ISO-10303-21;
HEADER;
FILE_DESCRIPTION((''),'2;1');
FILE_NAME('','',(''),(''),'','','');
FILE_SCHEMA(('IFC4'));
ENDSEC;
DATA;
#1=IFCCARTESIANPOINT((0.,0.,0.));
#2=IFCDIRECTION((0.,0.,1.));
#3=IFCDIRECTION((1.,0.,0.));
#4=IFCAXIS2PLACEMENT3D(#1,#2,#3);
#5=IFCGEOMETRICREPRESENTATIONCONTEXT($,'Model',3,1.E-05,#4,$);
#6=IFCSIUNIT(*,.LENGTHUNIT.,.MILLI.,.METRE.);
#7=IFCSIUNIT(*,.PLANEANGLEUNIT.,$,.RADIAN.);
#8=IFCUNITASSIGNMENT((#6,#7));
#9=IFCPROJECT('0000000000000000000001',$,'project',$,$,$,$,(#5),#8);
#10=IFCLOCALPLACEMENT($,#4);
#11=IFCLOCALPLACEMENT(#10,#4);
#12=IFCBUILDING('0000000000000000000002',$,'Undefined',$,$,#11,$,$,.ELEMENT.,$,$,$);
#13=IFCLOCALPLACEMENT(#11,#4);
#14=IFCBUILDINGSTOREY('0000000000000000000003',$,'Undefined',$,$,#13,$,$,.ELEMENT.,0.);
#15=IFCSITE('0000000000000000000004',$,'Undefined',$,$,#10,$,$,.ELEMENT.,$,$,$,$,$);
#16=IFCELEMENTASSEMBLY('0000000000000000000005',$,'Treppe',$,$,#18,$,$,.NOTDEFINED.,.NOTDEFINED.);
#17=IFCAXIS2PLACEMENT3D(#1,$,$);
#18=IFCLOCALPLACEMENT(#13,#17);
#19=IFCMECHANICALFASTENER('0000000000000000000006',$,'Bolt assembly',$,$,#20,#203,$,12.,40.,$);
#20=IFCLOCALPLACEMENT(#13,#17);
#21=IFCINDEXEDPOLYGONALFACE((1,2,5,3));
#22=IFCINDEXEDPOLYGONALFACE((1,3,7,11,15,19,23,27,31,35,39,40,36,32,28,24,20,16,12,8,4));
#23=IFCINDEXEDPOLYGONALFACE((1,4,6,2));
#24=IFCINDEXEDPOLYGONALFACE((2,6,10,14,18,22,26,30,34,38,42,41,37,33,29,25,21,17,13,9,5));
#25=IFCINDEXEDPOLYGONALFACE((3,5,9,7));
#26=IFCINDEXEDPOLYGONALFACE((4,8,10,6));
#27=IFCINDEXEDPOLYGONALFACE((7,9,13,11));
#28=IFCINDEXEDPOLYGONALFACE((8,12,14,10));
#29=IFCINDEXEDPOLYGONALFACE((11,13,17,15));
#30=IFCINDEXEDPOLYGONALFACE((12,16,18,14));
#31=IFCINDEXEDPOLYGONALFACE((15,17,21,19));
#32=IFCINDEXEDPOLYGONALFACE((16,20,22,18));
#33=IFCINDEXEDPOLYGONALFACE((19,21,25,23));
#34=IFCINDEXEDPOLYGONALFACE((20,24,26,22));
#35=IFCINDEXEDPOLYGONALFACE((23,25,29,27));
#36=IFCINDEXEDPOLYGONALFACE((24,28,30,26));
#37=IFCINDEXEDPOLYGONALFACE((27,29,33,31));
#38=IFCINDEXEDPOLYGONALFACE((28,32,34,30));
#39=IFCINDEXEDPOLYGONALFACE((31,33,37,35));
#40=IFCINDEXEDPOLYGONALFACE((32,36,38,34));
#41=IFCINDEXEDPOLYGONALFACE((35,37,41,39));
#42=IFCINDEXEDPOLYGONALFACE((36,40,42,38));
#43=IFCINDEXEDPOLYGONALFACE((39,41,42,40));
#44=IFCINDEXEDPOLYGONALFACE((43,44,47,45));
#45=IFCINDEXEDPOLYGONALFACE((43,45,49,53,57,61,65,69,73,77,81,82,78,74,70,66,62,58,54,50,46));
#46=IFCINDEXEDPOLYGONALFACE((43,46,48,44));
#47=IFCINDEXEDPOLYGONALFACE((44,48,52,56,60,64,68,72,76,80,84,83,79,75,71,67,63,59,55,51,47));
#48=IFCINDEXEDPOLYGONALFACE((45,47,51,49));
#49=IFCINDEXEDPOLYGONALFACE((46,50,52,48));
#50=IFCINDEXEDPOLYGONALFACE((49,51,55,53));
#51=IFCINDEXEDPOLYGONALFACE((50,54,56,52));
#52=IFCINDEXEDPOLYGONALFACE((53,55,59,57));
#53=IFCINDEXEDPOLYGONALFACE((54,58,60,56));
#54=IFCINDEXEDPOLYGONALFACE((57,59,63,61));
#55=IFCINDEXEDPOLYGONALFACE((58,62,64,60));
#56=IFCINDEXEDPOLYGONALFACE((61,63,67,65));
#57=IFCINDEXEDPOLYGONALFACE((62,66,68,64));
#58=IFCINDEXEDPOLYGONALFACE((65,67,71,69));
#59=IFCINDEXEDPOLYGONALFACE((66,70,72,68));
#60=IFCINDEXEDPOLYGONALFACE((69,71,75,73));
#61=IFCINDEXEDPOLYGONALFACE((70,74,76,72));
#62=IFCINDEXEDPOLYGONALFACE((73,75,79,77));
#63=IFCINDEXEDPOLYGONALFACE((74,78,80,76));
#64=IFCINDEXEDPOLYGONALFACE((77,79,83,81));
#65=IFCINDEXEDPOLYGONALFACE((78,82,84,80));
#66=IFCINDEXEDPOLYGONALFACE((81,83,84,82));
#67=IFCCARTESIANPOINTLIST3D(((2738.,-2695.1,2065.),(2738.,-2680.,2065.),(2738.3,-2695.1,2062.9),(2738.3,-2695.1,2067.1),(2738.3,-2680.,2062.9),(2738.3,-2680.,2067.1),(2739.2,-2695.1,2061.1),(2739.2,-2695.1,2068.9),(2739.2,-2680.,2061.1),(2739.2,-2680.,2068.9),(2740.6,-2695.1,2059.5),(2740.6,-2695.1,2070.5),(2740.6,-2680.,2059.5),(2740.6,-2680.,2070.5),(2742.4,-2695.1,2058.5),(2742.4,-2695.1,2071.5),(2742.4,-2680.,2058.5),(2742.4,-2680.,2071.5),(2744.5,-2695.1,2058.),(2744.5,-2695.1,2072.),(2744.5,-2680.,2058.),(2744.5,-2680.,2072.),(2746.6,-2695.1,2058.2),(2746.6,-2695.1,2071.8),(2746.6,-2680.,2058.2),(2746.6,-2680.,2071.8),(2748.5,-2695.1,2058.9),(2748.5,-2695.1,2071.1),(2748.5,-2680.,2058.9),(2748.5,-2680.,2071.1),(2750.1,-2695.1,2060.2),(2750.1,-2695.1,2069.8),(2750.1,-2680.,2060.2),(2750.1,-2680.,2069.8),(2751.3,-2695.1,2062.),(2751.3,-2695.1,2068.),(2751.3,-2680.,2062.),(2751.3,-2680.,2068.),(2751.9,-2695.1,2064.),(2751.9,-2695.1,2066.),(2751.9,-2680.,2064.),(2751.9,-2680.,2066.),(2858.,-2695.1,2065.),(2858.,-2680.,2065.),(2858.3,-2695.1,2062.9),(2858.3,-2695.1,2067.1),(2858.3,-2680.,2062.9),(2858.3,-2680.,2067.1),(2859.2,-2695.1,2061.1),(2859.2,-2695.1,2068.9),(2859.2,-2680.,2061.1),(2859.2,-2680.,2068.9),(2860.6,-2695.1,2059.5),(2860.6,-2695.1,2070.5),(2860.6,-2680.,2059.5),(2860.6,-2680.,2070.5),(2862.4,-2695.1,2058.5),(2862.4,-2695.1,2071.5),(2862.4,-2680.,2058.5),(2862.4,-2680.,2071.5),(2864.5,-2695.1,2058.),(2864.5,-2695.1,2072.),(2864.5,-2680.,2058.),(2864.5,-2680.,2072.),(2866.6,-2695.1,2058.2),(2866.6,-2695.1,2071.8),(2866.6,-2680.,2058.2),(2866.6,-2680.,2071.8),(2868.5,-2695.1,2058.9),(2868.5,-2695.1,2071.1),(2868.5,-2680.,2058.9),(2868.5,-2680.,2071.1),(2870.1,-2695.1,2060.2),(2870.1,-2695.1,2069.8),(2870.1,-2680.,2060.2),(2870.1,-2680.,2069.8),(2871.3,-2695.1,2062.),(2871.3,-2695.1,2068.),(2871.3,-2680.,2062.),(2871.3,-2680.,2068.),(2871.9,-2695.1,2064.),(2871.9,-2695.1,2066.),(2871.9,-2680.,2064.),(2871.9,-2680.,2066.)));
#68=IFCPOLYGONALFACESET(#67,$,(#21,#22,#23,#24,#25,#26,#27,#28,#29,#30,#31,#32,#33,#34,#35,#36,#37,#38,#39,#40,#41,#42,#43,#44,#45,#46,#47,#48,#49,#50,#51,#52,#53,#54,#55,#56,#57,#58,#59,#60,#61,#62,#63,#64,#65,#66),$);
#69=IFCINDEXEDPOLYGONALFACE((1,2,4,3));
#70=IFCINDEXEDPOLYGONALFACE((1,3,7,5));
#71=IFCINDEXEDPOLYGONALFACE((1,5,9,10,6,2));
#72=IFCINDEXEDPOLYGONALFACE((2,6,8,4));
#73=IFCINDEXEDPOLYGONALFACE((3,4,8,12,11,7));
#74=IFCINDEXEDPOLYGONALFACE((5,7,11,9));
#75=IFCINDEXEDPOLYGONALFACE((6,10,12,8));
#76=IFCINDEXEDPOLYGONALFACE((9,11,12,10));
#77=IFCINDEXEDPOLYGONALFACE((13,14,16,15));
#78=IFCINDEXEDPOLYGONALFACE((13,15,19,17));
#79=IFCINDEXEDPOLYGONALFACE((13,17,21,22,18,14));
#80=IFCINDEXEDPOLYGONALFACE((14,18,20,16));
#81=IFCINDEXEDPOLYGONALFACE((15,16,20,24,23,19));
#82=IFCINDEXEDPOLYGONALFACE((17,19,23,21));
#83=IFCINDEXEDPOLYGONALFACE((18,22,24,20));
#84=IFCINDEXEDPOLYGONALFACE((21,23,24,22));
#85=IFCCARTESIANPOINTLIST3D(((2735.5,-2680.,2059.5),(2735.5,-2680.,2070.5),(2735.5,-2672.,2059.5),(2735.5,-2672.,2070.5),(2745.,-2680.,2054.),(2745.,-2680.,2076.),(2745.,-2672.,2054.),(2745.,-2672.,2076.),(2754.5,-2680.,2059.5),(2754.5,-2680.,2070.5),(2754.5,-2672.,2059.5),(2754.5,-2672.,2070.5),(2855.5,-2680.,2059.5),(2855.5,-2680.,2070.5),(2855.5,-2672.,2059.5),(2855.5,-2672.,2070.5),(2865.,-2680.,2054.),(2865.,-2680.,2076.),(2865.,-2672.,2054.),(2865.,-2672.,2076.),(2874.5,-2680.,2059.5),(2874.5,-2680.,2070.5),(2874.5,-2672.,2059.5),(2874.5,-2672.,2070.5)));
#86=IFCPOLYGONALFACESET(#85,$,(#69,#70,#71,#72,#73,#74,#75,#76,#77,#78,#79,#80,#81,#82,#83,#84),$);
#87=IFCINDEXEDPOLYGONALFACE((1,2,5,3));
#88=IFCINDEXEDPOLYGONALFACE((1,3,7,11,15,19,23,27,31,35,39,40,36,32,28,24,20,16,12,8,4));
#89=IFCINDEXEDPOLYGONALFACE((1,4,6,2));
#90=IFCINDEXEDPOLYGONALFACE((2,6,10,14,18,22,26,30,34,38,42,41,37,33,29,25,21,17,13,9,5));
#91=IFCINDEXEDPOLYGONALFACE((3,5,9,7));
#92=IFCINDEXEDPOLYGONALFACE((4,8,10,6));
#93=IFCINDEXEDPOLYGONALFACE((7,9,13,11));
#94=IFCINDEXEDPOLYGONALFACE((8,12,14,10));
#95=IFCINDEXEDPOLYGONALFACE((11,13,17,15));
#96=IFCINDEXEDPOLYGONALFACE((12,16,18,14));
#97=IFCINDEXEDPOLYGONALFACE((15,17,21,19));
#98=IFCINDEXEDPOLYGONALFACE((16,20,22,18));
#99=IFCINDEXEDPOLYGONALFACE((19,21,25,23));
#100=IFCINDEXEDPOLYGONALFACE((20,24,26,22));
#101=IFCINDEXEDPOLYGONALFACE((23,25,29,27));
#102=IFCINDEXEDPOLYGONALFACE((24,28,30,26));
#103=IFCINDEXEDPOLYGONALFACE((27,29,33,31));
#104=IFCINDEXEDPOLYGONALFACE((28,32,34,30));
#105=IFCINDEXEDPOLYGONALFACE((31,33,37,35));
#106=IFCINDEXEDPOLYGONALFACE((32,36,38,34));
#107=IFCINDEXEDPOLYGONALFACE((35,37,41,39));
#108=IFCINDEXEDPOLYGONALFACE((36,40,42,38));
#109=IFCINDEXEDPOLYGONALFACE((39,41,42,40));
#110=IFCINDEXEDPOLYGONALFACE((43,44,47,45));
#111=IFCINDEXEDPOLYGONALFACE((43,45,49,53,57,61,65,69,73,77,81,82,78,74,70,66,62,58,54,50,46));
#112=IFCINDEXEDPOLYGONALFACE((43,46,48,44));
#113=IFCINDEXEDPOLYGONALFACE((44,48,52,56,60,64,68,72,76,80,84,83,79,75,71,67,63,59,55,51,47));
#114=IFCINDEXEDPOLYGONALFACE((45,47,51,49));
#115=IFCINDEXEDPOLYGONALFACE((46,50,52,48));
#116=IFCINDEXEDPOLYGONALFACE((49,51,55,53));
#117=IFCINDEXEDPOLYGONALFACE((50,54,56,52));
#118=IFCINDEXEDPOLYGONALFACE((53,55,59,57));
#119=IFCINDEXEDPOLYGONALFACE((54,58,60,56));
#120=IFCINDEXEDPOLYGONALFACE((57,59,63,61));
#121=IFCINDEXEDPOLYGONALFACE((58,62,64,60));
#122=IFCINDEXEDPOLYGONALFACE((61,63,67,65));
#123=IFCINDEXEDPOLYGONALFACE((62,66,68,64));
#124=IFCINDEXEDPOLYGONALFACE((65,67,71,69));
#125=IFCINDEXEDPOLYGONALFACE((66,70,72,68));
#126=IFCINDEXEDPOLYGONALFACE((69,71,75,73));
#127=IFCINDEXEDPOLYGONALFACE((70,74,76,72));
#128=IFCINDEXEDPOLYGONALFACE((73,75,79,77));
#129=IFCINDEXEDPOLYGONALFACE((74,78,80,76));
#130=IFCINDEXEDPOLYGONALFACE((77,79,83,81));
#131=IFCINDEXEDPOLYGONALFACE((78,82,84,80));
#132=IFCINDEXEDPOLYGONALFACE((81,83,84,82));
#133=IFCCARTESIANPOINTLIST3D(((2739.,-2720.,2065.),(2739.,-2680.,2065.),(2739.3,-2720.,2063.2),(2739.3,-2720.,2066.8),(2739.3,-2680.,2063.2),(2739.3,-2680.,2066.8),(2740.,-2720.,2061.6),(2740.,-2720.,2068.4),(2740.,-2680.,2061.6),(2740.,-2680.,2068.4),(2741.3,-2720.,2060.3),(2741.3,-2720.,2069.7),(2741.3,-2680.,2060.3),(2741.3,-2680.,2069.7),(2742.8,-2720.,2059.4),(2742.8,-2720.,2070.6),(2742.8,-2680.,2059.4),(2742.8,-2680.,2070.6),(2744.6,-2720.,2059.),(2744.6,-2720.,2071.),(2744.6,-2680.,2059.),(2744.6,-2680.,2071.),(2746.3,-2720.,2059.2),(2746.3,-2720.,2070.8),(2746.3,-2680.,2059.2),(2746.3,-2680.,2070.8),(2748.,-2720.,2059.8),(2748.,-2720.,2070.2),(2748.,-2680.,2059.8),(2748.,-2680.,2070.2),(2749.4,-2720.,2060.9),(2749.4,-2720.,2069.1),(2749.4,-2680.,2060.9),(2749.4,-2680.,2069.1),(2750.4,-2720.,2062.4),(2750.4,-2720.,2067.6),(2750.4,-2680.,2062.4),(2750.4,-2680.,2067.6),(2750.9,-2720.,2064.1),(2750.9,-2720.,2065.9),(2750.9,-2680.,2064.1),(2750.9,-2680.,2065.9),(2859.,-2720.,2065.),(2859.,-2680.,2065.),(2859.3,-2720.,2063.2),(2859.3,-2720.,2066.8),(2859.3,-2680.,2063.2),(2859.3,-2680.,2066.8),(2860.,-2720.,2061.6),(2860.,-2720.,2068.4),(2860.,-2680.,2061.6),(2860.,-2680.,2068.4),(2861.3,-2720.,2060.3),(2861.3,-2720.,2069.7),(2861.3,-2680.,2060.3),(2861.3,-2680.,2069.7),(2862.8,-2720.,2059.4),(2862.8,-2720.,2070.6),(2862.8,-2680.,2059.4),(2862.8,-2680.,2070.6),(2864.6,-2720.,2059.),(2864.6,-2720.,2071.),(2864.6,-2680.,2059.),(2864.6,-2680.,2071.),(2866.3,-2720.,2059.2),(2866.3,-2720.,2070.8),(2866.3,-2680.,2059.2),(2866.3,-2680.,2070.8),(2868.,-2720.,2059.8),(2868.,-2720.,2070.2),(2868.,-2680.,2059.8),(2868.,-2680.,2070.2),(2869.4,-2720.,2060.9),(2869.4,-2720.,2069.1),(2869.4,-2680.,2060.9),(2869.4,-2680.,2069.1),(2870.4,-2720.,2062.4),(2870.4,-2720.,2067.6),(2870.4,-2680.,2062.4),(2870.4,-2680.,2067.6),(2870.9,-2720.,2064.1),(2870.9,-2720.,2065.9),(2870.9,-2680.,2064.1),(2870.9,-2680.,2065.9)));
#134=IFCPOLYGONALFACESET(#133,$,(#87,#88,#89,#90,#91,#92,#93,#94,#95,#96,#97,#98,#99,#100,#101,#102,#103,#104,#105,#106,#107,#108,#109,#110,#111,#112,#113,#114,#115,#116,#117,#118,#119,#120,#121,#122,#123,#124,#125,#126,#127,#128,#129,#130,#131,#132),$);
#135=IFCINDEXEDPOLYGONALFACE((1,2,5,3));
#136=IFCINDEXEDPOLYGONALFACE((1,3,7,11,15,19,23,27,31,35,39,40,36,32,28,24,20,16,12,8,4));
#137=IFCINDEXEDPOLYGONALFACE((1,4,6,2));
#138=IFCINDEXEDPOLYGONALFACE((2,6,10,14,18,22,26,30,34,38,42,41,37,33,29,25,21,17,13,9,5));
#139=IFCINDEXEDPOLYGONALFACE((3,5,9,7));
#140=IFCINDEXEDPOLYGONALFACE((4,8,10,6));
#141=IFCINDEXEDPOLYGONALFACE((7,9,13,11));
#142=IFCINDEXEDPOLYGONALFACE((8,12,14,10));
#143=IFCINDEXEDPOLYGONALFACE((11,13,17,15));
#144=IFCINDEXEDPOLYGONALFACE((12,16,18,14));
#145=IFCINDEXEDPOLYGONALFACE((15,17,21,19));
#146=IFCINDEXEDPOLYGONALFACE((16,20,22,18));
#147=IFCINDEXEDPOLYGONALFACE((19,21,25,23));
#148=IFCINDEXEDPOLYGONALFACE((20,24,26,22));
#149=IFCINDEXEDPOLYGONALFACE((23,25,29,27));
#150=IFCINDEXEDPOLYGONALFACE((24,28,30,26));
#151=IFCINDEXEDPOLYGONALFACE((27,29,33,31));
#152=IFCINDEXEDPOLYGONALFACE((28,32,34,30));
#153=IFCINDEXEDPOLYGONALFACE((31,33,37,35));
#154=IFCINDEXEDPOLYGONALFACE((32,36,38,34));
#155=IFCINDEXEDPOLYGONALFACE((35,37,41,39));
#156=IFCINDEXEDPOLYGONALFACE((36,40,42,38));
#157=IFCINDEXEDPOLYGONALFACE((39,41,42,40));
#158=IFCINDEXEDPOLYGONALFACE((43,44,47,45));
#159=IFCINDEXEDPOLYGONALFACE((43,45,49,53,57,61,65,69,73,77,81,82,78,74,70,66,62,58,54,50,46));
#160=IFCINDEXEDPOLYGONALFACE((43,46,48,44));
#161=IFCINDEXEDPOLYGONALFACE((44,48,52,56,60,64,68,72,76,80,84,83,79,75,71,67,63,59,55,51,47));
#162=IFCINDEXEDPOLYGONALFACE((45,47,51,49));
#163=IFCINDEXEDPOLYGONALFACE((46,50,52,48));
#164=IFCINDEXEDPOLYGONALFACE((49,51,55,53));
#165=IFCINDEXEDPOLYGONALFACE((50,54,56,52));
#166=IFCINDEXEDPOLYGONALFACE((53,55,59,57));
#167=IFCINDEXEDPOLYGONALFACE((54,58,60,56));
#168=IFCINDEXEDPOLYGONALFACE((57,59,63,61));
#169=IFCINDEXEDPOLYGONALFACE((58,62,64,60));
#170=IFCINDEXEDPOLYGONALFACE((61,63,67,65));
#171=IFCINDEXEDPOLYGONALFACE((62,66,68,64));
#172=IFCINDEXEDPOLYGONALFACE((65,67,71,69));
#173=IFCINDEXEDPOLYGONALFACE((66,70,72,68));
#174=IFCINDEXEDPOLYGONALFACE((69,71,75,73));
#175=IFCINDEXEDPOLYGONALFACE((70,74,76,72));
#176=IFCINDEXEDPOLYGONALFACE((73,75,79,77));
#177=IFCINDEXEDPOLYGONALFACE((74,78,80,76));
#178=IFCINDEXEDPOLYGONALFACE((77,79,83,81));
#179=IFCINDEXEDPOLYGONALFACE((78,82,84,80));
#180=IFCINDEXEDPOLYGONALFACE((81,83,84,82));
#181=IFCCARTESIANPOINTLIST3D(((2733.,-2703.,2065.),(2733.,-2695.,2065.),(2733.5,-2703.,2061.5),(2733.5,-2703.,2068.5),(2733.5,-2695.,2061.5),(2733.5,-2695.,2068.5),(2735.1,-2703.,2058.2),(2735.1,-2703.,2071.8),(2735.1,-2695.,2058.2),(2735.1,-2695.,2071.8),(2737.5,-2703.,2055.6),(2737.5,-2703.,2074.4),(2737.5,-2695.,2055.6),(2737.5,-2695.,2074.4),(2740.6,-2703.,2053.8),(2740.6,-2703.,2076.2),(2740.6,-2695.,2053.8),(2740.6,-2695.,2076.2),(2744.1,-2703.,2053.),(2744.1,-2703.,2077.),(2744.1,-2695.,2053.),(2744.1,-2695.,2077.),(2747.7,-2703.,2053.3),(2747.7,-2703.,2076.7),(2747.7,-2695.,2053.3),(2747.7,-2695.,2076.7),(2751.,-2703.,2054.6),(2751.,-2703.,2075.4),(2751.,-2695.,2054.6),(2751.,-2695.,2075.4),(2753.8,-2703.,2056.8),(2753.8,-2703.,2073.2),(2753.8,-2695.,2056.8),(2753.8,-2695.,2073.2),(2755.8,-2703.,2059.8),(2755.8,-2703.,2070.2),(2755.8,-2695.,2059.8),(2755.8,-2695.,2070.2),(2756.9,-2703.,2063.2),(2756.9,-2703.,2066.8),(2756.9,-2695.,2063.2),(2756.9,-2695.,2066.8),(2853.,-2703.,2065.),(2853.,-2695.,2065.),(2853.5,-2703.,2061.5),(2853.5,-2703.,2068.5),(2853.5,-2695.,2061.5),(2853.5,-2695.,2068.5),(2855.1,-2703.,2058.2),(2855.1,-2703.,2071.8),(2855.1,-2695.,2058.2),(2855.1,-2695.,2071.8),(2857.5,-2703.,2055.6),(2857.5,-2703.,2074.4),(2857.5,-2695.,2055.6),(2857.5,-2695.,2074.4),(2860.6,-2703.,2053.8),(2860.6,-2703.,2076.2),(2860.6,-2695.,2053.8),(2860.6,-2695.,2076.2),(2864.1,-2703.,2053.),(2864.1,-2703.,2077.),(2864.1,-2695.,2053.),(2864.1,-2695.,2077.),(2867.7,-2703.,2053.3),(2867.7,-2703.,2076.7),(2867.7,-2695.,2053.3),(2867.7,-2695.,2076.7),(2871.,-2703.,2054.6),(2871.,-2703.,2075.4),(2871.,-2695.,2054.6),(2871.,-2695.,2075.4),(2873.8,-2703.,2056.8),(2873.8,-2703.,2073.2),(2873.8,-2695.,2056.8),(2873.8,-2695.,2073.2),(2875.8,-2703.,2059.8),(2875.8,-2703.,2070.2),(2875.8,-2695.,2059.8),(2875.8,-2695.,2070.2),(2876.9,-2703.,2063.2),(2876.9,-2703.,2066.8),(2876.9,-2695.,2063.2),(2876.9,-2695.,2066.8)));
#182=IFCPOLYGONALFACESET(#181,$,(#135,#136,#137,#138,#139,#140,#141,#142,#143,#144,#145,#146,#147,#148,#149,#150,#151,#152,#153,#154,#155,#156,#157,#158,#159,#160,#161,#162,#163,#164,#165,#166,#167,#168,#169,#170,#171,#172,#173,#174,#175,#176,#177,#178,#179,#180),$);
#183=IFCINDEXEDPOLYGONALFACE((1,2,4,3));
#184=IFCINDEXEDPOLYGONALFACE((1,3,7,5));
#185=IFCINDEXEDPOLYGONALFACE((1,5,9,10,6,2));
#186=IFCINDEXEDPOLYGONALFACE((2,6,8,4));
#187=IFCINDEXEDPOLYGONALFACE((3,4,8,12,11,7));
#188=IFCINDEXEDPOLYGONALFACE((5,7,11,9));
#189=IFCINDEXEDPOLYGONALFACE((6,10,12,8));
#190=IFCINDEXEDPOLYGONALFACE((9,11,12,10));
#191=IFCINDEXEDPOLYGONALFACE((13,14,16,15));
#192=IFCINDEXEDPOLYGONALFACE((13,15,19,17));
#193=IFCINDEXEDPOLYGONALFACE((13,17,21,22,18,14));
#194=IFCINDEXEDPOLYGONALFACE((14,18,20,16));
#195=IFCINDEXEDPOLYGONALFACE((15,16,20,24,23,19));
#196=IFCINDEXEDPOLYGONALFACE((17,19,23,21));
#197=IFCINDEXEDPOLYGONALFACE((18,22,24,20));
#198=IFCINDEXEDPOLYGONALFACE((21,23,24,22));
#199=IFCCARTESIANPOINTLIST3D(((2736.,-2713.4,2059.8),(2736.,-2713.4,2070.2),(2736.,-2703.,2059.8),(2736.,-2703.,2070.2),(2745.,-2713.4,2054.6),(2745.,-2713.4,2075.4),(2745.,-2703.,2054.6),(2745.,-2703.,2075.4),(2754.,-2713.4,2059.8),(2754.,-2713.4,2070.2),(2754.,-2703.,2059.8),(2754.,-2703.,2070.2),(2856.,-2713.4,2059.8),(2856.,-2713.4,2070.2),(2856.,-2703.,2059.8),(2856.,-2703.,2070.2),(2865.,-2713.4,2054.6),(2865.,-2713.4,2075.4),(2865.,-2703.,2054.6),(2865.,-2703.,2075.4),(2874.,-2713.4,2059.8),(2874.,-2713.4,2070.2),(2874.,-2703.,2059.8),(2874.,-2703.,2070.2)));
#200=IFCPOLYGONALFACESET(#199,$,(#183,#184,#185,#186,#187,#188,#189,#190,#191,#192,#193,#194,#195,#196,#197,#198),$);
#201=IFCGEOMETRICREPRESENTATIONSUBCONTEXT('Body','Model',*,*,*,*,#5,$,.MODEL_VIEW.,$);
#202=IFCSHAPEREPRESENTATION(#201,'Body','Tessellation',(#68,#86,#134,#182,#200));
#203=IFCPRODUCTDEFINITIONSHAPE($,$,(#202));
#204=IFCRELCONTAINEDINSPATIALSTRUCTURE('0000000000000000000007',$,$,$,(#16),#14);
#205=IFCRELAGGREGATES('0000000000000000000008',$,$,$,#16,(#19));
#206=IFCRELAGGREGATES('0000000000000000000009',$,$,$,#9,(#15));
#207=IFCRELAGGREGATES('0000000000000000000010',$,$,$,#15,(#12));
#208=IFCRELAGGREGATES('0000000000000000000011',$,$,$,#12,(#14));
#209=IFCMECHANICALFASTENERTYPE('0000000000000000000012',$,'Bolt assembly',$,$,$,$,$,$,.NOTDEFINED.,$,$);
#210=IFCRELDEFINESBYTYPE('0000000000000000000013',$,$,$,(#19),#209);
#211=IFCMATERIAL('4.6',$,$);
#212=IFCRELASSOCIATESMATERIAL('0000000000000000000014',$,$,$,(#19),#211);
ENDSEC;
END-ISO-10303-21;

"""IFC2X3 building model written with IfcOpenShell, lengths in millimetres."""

from ifc_helpers import new_model, si_unit, frame, origin_with_axes, origin_2d_with_axis, place, context, subcontext, project, spatial, polyline, circle, outline, extrude, source, transform, mapped, material, type_object, element, aggregate, save


model = new_model("IFC2X3")

# Units and contexts
model_context = context("Model", 3, precision=1e-05, world=origin_with_axes())
body_context = subcontext(model_context, "Body", "Model", "MODEL_VIEW")
ifc_project = project(units=[si_unit("LENGTHUNIT", "METRE", prefix="MILLI"), si_unit("PLANEANGLEUNIT", "RADIAN")], contexts=[model_context])

# Site, building, storey
site_placement = place(None, origin_with_axes())
site = spatial("IfcSite", under=ifc_project, at=site_placement, Name="Undefined", CompositionType="ELEMENT")
building_placement = place(site_placement, origin_with_axes())
building = spatial("IfcBuilding", under=site, at=building_placement, Name="Undefined", CompositionType="ELEMENT")
storey_placement = place(building_placement, origin_with_axes())
storey = spatial("IfcBuildingStorey", under=building, at=storey_placement, Name="Undefined", CompositionType="ELEMENT", Elevation=0.0)

# Shared definitions
mechanical_fastener_type = type_object("IfcMechanicalFastenerType", Name="Bolt assembly")

# Shared definitions
ifc_material_1 = material(Name="4.6")

# Element assembly, mechanical fastener
assembly_1_placement = place(storey_placement, origin_with_axes())
assembly_1 = element("IfcElementAssembly", 1, at=assembly_1_placement, inside=storey, Name="Treppe", AssemblyPlace="NOTDEFINED", PredefinedType="NOTDEFINED")
shared_shape_1 = source(origin_with_axes(), body_context, "Body", "SweptSolid", [
    extrude(circle(Radius=7.0, at=origin_2d_with_axis()), frame((0.0, -15.0, 0.0), z_axis=(0.0, 1.0, 0.0), x_axis=(1.0, 0.0, 0.0)), (0.0, 0.0, 1.0), 15.1),
    extrude(outline(polyline([(9.5, -5.5), (9.5, 5.5), (0.0, 11.0), (-9.5, 5.5), (-9.5, -5.5), (0.0, -11.0), (9.5, -5.5)])), frame((0.0, -23.0, 0.0), z_axis=(0.0, 1.0, 0.0), x_axis=(1.0, 0.0, 0.0)), (0.0, 0.0, 1.0), 8.0),
    extrude(circle(Radius=6.0, at=origin_2d_with_axis()), frame((0.0, -15.0, 0.0), z_axis=(0.0, 1.0, 0.0), x_axis=(1.0, 0.0, 0.0)), (0.0, 0.0, 1.0), 40.0),
    extrude(circle(Radius=12.0, at=origin_2d_with_axis()), frame((0.0, 0.0, 0.0), z_axis=(0.0, 1.0, 0.0), x_axis=(1.0, 0.0, 0.0)), (0.0, 0.0, 1.0), 8.0),
    extrude(outline(polyline([(9.0, -5.2), (9.0, 5.2), (0.0, 10.4), (-9.0, 5.2), (-9.0, -5.2), (0.0, -10.4), (9.0, -5.2)])), frame((0.0, 8.0, 0.0), z_axis=(0.0, 1.0, 0.0), x_axis=(1.0, 0.0, 0.0)), (0.0, 0.0, 1.0), 10.4),
])
mechanical_fastener_1_placement = place(assembly_1_placement, frame((2865.0, -2695.0, 2065.0), z_axis=(0.0, 0.0, 1.0), x_axis=(-1.0, 0.0, 0.0)))
mechanical_fastener_1 = element("IfcMechanicalFastener", 2, at=mechanical_fastener_1_placement, type_object=mechanical_fastener_type, material=ifc_material_1, Name="Bolt assembly", NominalDiameter=12.0, NominalLength=40.0, context=body_context, shape_type="MappedRepresentation", body=[
    mapped(shared_shape_1, transform((0.0, 0.0, 0.0))),
    mapped(shared_shape_1, transform((120.0, 0.0, 0.0))),
])
aggregate(assembly_1, [mechanical_fastener_1])

save(model, "model.ifc")
